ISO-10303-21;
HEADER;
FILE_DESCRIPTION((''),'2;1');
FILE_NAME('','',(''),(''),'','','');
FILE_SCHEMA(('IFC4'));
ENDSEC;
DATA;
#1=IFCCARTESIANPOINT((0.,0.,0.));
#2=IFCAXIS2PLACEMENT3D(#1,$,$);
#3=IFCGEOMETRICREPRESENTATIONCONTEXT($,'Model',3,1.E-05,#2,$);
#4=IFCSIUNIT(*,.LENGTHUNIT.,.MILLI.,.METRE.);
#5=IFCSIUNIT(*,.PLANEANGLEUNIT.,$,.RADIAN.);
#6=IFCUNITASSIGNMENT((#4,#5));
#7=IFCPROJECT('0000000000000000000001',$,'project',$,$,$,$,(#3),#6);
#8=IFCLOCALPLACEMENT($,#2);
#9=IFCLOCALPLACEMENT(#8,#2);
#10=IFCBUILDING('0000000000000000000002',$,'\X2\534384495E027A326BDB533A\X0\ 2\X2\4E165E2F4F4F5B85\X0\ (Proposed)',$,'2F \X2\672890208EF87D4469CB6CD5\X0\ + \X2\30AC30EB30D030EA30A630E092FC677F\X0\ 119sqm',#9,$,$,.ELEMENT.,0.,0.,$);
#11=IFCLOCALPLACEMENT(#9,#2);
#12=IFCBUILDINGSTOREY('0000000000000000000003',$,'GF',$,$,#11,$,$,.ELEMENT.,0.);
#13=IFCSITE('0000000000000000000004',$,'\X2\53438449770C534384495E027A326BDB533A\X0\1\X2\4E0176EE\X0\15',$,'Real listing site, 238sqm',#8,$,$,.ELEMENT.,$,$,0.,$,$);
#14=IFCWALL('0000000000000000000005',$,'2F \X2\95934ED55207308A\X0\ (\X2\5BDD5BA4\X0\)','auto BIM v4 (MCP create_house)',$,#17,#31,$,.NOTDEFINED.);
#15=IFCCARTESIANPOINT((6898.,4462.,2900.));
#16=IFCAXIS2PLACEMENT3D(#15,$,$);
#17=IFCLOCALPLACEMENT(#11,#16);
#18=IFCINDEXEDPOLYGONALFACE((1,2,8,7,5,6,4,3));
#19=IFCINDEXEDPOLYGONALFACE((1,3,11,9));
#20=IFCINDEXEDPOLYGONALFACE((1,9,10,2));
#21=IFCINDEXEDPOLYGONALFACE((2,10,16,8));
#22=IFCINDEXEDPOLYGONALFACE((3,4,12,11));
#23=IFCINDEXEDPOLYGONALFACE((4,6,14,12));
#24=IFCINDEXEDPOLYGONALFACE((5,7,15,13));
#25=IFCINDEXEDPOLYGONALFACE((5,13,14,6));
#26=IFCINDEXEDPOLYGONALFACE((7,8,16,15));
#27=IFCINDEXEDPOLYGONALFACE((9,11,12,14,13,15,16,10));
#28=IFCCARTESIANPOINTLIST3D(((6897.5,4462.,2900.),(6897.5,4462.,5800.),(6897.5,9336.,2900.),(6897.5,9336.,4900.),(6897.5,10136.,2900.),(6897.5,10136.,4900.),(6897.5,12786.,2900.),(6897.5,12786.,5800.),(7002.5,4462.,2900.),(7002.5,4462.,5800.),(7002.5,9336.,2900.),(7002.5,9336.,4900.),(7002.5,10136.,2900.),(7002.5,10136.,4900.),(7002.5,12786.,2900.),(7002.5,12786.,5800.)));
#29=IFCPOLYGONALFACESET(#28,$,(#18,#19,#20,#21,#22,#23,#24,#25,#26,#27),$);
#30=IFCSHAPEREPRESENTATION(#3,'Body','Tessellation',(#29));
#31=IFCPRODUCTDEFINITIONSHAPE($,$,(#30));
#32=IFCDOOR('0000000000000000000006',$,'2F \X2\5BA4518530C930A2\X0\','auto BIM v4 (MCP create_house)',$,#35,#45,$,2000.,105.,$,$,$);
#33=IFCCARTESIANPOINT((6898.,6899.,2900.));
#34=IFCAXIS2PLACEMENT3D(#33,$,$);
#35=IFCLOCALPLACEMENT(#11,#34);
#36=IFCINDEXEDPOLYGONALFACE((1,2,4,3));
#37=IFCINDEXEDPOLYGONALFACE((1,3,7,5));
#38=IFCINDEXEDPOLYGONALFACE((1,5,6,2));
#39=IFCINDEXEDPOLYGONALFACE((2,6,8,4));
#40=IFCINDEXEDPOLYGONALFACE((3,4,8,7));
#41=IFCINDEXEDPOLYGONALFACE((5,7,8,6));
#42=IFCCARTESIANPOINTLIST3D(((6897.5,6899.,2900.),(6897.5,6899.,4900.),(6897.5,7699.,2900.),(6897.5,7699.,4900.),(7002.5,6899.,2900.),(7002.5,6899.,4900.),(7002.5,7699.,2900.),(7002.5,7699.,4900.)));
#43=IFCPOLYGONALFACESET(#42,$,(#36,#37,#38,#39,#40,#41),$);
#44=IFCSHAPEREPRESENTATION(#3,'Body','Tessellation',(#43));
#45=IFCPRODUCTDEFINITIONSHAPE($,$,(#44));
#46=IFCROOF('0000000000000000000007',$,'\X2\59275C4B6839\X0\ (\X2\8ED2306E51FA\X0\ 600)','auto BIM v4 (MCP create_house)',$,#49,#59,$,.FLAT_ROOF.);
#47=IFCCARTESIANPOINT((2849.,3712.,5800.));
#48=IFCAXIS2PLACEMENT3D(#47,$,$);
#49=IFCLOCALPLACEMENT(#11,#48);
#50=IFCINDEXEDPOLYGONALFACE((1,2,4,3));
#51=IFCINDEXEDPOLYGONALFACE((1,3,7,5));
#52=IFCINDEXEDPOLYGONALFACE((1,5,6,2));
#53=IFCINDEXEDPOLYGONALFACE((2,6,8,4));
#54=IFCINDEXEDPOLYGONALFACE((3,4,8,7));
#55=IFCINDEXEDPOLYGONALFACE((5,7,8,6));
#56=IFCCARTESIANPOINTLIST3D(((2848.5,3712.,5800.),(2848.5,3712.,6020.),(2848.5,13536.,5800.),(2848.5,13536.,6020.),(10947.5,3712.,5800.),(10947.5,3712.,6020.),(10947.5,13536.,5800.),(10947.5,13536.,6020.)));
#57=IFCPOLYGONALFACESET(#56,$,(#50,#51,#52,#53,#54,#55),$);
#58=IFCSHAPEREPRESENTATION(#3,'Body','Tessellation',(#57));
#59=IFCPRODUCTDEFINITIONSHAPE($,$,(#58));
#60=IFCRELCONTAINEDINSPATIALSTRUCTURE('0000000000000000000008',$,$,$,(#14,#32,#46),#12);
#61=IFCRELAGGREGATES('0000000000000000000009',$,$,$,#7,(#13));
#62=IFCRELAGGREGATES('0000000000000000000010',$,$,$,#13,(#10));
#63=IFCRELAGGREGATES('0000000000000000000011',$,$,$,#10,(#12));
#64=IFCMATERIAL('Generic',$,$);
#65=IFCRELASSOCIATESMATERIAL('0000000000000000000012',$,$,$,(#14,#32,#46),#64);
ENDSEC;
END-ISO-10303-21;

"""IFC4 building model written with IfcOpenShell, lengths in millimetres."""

from ifc_helpers import new_model, si_unit, frame, frame_2d, origin, place, context, project, spatial, rectangle, extrude, material, element, fill, save


model = new_model("IFC4")

# Units and contexts
model_context = context("Model", 3, precision=1e-05, world=origin())
ifc_project = project(units=[si_unit("LENGTHUNIT", "METRE", prefix="MILLI"), si_unit("PLANEANGLEUNIT", "RADIAN")], contexts=[model_context])

# Site, building, storey
site_placement = place(None, origin())
site = spatial("IfcSite", under=ifc_project, at=site_placement, Name="千葉県千葉市稲毛区1丁目15", ObjectType="Real listing site, 238sqm", CompositionType="ELEMENT", RefElevation=0.0)
building_placement = place(site_placement, origin())
building = spatial("IfcBuilding", under=site, at=building_placement, Name="千葉市稲毛区 2世帯住宅 (Proposed)", ObjectType="2F 木造軸組構法 + ガルバリウム鋼板 119sqm", CompositionType="ELEMENT", ElevationOfRefHeight=0.0, ElevationOfTerrain=0.0)
storey_placement = place(building_placement, origin())
storey = spatial("IfcBuildingStorey", under=building, at=storey_placement, Name="GF", CompositionType="ELEMENT", Elevation=0.0)

# Shared definitions
ifc_material = material(Name="Generic")

# Wall, opening, door
wall_1_placement = place(storey_placement, frame((6898.0, 4462.0, 2900.0)))
wall_1 = element("IfcWall", 1, at=wall_1_placement, inside=storey, material=ifc_material, Name="2F 間仕切り (寝室)", Description="auto BIM v4 (MCP create_house)", PredefinedType="NOTDEFINED", context=model_context, shape_type="SweptSolid", body=[
    extrude(rectangle(XDim=105.0, YDim=8324.0, at=frame_2d((52.0, 4162.0))), frame((6898.0, 4462.0, 2900.0)), (0.0, 0.0, 1.0), 2900.0),
])
opening_1_placement = place(storey_placement, frame((6898.0, 6899.0, 2900.0)))
opening_1 = element("IfcOpeningElement", 2, at=opening_1_placement, cuts=wall_1, PredefinedType="NOTDEFINED", context=model_context, shape_type="SweptSolid", body=[
    extrude(rectangle(XDim=105.0, YDim=800.0, at=frame_2d((52.0, 400.0))), frame((6898.0, 6899.0, 2900.0)), (0.0, 0.0, 1.0), 2000.0),
])
door_1_placement = place(storey_placement, frame((6898.0, 6899.0, 2900.0)))
door_1 = element("IfcDoor", 3, at=door_1_placement, inside=storey, material=ifc_material, Name="2F 室内ドア", Description="auto BIM v4 (MCP create_house)", OverallHeight=2000.0, OverallWidth=105.0, context=model_context, shape_type="SweptSolid", body=[
    extrude(rectangle(XDim=105.0, YDim=800.0, at=frame_2d((52.0, 400.0))), frame((6898.0, 6899.0, 2900.0)), (0.0, 0.0, 1.0), 2000.0),
])
fill(opening_1, door_1)

# Roof
roof_placement = place(storey_placement, frame((2849.0, 3712.0, 5800.0)))
element("IfcRoof", 4, at=roof_placement, inside=storey, material=ifc_material, Name="大屋根 (軒の出 600)", Description="auto BIM v4 (MCP create_house)", PredefinedType="FLAT_ROOF", context=model_context, shape_type="SweptSolid", body=[
    extrude(rectangle(XDim=8099.0, YDim=9824.0, at=frame_2d((4049.0, 4912.0))), frame((2849.0, 3712.0, 5800.0)), (0.0, 0.0, 1.0), 220.0),
])

save(model, "model.ifc")
